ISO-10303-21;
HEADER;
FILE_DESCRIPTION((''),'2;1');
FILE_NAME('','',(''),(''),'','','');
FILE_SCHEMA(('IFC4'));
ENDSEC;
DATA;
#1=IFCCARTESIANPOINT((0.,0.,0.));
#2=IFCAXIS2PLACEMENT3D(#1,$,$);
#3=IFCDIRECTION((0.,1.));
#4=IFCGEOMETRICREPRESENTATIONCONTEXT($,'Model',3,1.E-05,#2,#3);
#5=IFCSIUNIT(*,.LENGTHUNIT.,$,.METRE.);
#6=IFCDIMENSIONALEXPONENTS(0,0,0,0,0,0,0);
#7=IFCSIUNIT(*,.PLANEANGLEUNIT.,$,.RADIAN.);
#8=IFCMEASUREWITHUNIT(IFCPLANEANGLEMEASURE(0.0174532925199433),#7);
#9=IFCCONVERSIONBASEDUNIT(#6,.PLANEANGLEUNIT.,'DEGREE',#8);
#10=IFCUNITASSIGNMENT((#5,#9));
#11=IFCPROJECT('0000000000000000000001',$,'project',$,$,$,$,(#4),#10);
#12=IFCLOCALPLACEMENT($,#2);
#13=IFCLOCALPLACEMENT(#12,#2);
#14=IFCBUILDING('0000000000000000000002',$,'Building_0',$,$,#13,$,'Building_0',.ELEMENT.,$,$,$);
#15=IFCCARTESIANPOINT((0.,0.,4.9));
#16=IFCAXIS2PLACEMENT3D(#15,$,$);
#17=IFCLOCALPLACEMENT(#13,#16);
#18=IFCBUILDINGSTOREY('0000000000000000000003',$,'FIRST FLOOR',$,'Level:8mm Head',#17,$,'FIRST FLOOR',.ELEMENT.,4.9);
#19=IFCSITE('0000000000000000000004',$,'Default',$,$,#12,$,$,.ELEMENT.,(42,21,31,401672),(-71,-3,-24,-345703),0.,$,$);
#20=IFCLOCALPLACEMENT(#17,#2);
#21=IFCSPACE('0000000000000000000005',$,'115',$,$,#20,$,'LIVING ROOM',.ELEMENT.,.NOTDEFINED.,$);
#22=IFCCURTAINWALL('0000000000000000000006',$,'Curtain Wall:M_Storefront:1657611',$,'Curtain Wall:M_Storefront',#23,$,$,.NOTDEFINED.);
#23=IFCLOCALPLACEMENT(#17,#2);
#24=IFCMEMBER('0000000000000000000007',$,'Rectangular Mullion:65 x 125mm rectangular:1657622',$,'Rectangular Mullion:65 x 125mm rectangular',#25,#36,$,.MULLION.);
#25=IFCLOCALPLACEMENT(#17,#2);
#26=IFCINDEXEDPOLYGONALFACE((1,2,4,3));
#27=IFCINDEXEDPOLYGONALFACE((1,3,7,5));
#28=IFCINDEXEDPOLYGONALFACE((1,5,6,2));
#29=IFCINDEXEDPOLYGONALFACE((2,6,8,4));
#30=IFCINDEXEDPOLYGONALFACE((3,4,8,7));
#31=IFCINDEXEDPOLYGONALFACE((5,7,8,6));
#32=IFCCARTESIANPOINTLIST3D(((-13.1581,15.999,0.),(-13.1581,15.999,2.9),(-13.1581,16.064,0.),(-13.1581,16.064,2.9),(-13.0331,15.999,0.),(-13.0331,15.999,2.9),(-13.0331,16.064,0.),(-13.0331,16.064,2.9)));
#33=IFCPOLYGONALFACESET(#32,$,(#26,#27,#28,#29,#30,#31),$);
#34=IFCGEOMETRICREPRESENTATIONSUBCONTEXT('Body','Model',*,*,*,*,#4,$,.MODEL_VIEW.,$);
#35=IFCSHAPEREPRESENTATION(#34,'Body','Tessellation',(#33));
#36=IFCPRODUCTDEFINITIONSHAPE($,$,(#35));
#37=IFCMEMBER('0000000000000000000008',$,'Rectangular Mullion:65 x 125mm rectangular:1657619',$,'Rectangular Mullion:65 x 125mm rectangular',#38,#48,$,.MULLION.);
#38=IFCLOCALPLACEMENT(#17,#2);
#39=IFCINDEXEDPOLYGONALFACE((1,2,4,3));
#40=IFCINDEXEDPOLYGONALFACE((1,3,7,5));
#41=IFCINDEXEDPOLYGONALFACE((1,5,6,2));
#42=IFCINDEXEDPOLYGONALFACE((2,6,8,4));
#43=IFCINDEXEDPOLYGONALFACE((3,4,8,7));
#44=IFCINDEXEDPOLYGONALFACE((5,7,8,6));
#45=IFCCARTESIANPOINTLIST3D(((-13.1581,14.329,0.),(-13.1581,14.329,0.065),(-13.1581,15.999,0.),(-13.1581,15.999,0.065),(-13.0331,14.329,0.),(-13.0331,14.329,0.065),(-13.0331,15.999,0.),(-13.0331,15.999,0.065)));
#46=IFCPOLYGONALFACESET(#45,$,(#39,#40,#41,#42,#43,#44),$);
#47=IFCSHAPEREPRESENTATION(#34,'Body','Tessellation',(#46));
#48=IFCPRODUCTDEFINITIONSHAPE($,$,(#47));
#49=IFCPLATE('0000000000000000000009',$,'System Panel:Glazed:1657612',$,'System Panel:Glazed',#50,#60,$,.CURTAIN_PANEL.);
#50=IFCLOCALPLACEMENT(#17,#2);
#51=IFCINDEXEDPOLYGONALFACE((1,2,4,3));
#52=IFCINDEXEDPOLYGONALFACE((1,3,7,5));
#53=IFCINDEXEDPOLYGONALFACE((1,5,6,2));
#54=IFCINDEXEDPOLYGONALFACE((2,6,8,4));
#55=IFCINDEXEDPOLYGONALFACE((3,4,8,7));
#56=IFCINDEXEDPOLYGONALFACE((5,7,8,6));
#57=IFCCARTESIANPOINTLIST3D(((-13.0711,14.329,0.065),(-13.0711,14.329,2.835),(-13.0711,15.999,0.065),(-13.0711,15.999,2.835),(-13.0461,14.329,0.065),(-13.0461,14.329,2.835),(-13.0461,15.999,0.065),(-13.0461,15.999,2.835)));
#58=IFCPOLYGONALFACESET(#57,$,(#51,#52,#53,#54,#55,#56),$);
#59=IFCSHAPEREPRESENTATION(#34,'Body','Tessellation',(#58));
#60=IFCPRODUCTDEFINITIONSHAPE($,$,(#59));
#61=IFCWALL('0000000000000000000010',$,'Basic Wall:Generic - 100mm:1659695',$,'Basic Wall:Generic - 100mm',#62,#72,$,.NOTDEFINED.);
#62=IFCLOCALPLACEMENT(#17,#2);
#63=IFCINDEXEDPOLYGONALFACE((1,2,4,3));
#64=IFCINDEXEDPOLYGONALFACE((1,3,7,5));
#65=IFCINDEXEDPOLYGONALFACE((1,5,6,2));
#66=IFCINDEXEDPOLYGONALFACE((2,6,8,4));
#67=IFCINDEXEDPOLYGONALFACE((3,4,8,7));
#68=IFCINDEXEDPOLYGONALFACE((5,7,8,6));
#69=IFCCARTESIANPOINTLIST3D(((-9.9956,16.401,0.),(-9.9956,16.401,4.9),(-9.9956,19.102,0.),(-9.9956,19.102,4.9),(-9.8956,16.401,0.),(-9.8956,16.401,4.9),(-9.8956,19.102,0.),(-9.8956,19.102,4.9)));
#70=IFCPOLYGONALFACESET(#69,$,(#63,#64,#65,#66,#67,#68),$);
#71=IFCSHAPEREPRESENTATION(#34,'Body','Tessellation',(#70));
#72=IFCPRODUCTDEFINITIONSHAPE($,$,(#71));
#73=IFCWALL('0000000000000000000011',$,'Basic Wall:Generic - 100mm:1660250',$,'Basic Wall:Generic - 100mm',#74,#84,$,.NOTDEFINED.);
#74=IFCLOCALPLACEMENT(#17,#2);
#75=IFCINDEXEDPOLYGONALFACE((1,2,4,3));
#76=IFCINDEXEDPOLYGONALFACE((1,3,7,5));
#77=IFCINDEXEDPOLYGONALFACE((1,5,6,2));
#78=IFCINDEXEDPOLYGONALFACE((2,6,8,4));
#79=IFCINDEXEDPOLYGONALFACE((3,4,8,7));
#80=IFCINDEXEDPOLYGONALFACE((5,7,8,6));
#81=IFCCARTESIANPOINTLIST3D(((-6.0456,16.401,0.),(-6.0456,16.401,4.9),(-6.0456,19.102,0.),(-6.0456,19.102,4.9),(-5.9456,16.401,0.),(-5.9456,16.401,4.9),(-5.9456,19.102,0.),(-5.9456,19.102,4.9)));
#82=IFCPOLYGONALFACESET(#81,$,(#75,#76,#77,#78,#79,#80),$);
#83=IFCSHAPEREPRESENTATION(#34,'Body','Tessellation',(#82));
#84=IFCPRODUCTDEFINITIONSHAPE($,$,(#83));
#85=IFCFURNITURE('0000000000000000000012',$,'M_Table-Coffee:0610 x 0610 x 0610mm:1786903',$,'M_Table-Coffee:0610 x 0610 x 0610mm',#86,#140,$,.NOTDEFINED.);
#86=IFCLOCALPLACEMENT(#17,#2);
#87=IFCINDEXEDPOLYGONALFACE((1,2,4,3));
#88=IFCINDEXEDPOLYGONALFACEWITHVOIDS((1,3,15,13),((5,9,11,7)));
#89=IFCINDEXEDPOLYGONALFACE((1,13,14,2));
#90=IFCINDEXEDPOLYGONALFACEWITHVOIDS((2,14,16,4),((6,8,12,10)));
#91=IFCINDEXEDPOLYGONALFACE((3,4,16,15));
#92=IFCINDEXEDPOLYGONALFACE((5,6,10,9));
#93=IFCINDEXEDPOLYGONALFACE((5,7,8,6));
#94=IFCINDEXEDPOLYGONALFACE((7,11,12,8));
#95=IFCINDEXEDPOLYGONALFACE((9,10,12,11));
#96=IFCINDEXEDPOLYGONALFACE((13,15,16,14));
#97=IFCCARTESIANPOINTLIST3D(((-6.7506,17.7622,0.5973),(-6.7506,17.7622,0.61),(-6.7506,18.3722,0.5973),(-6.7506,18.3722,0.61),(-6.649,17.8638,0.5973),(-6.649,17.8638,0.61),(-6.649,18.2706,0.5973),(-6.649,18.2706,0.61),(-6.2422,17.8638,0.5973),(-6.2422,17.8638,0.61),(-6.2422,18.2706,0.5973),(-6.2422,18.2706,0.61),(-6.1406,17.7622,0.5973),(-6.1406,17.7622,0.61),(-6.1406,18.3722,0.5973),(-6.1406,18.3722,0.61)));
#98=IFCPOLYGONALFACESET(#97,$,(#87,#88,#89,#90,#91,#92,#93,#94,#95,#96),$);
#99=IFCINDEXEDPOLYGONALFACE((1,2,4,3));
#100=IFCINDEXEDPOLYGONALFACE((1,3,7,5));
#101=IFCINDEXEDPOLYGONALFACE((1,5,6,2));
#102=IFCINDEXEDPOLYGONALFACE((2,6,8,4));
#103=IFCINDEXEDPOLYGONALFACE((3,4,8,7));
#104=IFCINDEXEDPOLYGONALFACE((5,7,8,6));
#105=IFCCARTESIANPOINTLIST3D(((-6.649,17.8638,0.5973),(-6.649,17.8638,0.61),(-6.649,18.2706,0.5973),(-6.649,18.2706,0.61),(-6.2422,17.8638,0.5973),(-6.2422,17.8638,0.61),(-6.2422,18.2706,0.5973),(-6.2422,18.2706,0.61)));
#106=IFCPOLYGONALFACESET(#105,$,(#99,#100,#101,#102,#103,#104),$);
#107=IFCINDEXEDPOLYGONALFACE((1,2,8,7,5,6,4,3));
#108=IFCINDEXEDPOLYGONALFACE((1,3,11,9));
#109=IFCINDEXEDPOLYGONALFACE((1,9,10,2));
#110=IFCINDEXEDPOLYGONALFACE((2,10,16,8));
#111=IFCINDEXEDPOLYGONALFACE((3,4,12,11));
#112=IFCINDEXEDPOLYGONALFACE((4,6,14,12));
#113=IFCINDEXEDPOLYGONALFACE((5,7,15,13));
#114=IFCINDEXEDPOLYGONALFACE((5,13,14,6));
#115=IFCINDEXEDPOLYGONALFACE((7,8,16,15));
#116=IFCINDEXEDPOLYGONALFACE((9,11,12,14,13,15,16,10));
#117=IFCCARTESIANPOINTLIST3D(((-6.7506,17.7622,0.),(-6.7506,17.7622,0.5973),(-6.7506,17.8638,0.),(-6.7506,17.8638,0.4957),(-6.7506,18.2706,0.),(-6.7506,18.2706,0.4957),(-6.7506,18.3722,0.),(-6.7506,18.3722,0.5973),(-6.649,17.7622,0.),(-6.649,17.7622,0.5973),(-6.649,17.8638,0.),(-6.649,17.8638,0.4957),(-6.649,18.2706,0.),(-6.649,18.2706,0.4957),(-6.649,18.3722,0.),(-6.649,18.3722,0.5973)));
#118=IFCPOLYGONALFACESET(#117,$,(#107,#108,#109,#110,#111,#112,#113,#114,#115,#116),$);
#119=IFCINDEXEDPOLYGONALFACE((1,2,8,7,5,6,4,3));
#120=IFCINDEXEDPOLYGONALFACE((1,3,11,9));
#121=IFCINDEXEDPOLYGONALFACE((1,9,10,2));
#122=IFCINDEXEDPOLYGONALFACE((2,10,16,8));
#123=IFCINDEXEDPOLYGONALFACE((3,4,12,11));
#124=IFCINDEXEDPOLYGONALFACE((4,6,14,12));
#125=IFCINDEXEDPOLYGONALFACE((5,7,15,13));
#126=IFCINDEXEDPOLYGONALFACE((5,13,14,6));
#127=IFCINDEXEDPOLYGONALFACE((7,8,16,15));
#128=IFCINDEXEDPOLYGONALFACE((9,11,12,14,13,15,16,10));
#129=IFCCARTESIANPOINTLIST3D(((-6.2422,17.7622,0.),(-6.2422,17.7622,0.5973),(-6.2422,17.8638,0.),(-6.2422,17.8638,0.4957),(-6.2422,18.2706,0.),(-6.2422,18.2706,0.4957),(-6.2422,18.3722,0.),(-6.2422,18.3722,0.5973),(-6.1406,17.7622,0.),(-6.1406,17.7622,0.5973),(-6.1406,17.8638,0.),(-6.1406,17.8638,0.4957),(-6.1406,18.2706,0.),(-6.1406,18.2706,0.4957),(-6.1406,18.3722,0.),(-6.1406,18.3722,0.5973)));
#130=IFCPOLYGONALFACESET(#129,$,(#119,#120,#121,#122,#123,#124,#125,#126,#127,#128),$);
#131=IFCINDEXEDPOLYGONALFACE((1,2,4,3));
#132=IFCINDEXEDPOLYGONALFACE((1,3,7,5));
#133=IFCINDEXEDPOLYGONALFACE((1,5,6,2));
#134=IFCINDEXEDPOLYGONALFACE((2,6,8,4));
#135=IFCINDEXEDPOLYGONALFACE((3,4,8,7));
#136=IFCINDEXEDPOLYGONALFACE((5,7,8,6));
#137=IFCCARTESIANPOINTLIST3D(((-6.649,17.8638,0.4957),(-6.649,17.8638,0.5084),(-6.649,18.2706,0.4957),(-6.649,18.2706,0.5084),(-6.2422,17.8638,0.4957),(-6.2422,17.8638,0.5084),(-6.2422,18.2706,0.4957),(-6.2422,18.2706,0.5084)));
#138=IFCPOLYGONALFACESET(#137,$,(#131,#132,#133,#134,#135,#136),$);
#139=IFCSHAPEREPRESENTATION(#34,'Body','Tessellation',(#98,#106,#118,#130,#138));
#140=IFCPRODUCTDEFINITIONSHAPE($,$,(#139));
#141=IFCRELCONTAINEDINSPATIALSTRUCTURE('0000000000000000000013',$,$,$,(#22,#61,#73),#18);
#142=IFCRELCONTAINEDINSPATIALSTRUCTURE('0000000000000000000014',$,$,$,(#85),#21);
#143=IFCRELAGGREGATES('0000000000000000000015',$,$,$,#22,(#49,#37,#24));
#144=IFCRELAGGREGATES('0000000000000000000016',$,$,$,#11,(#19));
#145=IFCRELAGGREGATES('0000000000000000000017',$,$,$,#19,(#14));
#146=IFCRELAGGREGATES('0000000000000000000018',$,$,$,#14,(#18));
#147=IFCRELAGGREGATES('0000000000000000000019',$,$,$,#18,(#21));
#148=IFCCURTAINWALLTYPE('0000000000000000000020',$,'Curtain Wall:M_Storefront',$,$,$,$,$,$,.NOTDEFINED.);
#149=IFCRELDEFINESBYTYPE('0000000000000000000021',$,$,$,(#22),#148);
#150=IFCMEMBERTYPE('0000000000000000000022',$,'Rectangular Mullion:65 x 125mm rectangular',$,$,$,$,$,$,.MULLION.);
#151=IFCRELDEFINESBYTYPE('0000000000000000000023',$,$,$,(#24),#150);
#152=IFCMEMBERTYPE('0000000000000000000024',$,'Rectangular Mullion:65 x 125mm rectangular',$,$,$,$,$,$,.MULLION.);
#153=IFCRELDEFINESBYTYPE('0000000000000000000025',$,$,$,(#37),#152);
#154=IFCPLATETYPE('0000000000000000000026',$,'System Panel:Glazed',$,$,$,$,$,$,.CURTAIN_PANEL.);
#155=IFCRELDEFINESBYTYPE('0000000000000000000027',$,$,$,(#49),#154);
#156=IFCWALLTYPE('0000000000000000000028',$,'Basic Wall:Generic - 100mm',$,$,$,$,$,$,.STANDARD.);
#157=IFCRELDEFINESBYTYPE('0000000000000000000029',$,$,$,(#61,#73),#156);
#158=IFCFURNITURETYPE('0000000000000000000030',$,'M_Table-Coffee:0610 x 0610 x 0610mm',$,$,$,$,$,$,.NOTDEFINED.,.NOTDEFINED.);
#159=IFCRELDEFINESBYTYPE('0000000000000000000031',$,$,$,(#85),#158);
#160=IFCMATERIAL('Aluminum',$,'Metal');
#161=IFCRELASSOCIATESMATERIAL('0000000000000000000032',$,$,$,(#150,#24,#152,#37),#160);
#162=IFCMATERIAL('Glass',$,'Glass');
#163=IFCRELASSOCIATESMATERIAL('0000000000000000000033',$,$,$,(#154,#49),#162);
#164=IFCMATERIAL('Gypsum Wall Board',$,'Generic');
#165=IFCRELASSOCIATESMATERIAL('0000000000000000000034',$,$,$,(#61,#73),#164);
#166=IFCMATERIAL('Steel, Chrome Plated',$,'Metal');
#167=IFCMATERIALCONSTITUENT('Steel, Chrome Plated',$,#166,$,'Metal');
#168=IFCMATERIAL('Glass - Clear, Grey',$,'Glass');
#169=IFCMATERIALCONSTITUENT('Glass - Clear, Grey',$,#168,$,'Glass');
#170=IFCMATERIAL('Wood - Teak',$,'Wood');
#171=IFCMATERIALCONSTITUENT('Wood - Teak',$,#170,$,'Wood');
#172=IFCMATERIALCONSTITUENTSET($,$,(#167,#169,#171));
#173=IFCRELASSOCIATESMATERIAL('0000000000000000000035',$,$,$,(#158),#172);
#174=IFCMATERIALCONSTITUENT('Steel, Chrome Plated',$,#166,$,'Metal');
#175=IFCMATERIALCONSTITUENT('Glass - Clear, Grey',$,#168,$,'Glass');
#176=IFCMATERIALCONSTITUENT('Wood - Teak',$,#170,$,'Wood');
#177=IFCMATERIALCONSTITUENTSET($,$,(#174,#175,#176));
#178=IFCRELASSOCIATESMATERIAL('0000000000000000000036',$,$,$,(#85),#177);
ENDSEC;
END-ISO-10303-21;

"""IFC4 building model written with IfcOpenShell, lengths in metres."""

from ifc_helpers import new_model, entity, si_unit, converted_unit, direction, frame, origin, place, context, subcontext, project, spatial, indexed_curve, outline, extrude, source, transform, mapped, material, constituent, constituent_set, type_object, type_shapes, element, aggregate, save


model = new_model("IFC4")

# Units and contexts
model_context = context("Model", 3, precision=1e-05, world=origin(), true_north=direction((0.0, 1.0)))
body_context = subcontext(model_context, "Body", "Model", "MODEL_VIEW")
ifc_project = project(units=[si_unit("LENGTHUNIT", "METRE"), converted_unit("PLANEANGLEUNIT", "DEGREE", entity("IfcPlaneAngleMeasure", 0.0174532925199433), si_unit("PLANEANGLEUNIT", "RADIAN"), dimensions=[0, 0, 0, 0, 0, 0, 0])], contexts=[model_context])

# Site, building, storey
site_placement = place(None, origin())
site = spatial("IfcSite", under=ifc_project, at=site_placement, Name="Default", CompositionType="ELEMENT", RefLatitude=(42, 21, 31, 401672), RefLongitude=(-71, -3, -24, -345703), RefElevation=0.0)
building_placement = place(site_placement, origin())
building = spatial("IfcBuilding", under=site, at=building_placement, Name="Building_0", LongName="Building_0", CompositionType="ELEMENT")
storey_placement = place(building_placement, frame((0.0, 0.0, 4.9)))
storey = spatial("IfcBuildingStorey", under=building, at=storey_placement, Name="FIRST FLOOR", ObjectType="Level:8mm Head", LongName="FIRST FLOOR", CompositionType="ELEMENT", Elevation=4.9)

# Curtain wall, members, plate
curtain_wall_type = type_object("IfcCurtainWallType", Name="Curtain Wall:M_Storefront", PredefinedType="NOTDEFINED")
curtain_wall_placement = place(storey_placement, frame((0.0, 0.0, -4.9)))
curtain_wall = element("IfcCurtainWall", 1, at=curtain_wall_placement, inside=storey, type_object=curtain_wall_type, Name="Curtain Wall:M_Storefront:1657611", ObjectType="Curtain Wall:M_Storefront", PredefinedType="NOTDEFINED")
ifc_material_1 = material(Name="Aluminum", Category="Metal")
member_type_1 = type_object("IfcMemberType", Name="Rectangular Mullion:65 x 125mm rectangular", PredefinedType="MULLION", material=ifc_material_1)
shared_shape_1 = source(origin(), body_context, "Body", "SweptSolid", [
    extrude(outline(indexed_curve([(-0.0325, -0.0625), (0.0325, -0.0625), (0.0325, 0.0625), (-0.0325, 0.0625), (-0.0325, -0.0625)], self_intersect=False)), frame((-0.0325, 0.0, -2.9), z_axis=(0.0, 0.0, 1.0), x_axis=(-1.0, 0.0, 0.0)), (0.0, 0.0, 1.0), 2.9),
])
type_shapes(member_type_1, [shared_shape_1])
member_1_placement = place(curtain_wall_placement, frame((-13.0956, 16.064, 7.8), z_axis=(0.0, 0.0, 1.0), x_axis=(0.0, 1.0, 0.0)))
member_1 = element("IfcMember", 2, at=member_1_placement, type_object=member_type_1, material=ifc_material_1, Name="Rectangular Mullion:65 x 125mm rectangular:1657622", ObjectType="Rectangular Mullion:65 x 125mm rectangular", PredefinedType="MULLION", context=body_context, shape_type="MappedRepresentation", body=[
    mapped(shared_shape_1, transform((0.0, 0.0, 0.0), scale=1.0)),
])
member_type_2 = type_object("IfcMemberType", Name="Rectangular Mullion:65 x 125mm rectangular", PredefinedType="MULLION", material=ifc_material_1)
shared_shape_2 = source(origin(), body_context, "Body", "SweptSolid", [
    extrude(outline(indexed_curve([(-0.0325, -0.0625), (0.0325, -0.0625), (0.0325, 0.0625), (-0.0325, 0.0625), (-0.0325, -0.0625)], self_intersect=False)), frame((-0.0325, 0.0, -1.67), z_axis=(0.0, 0.0, 1.0), x_axis=(-1.0, 0.0, 0.0)), (0.0, 0.0, 1.0), 1.67),
])
type_shapes(member_type_2, [shared_shape_2])
member_2_placement = place(curtain_wall_placement, frame((-13.0956, 15.999, 4.9), z_axis=(0.0, 1.0, 0.0), x_axis=(0.0, 0.0, -1.0)))
member_2 = element("IfcMember", 3, at=member_2_placement, type_object=member_type_2, material=ifc_material_1, Name="Rectangular Mullion:65 x 125mm rectangular:1657619", ObjectType="Rectangular Mullion:65 x 125mm rectangular", PredefinedType="MULLION", context=body_context, shape_type="MappedRepresentation", body=[
    mapped(shared_shape_2, transform((0.0, 0.0, 0.0), scale=1.0)),
])
ifc_material_2 = material(Name="Glass", Category="Glass")
plate_type = type_object("IfcPlateType", Name="System Panel:Glazed", PredefinedType="CURTAIN_PANEL", material=ifc_material_2)
shared_shape_3 = source(origin(), body_context, "Body", "SweptSolid", [
    extrude(outline(indexed_curve([(-0.0125, -0.835), (0.0125, -0.835), (0.0125, 0.835), (-0.0125, 0.835), (-0.0125, -0.835)], self_intersect=False)), frame((0.0, 0.037, 0.0), z_axis=(0.0, 0.0, 1.0), x_axis=(0.0, 1.0, 0.0)), (0.0, 0.0, 1.0), 2.77),
])
type_shapes(plate_type, [shared_shape_3])
plate_placement = place(curtain_wall_placement, frame((-13.0956, 15.164, 4.965), z_axis=(0.0, 0.0, 1.0), x_axis=(0.0, -1.0, 0.0)))
plate = element("IfcPlate", 4, at=plate_placement, type_object=plate_type, material=ifc_material_2, Name="System Panel:Glazed:1657612", ObjectType="System Panel:Glazed", PredefinedType="CURTAIN_PANEL", context=body_context, shape_type="MappedRepresentation", body=[
    mapped(shared_shape_3, transform((0.0, 0.0, 0.0), scale=1.0)),
])
aggregate(curtain_wall, [plate, member_2, member_1])

# Walls
ifc_material_3 = material(Name="Gypsum Wall Board", Category="Generic")
wall_type_1 = type_object("IfcWallType", Name="Basic Wall:Generic - 100mm", PredefinedType="STANDARD")
wall_1_placement = place(storey_placement, frame((-9.9456, 19.102, 0.0), z_axis=(0.0, 0.0, 1.0), x_axis=(0.0, -1.0, 0.0)))
element("IfcWall", 5, at=wall_1_placement, inside=storey, type_object=wall_type_1, material=ifc_material_3, Name="Basic Wall:Generic - 100mm:1659695", ObjectType="Basic Wall:Generic - 100mm", PredefinedType="NOTDEFINED", context=body_context, shape_type="SweptSolid", body=[
    extrude(outline(indexed_curve([(2.701, 0.05), (0.0, 0.05), (0.0, -0.05), (2.701, -0.05), (2.701, 0.05)], self_intersect=False)), origin(), (0.0, 0.0, 1.0), 4.9),
])
wall_2_placement = place(storey_placement, frame((-5.9956, 19.102, 0.0), z_axis=(0.0, 0.0, 1.0), x_axis=(0.0, -1.0, 0.0)))
element("IfcWall", 6, at=wall_2_placement, inside=storey, type_object=wall_type_1, material=ifc_material_3, Name="Basic Wall:Generic - 100mm:1660250", ObjectType="Basic Wall:Generic - 100mm", PredefinedType="NOTDEFINED", context=body_context, shape_type="SweptSolid", body=[
    extrude(outline(indexed_curve([(2.701, 0.05), (0.0, 0.05), (0.0, -0.05), (2.701, -0.05), (2.701, 0.05)], self_intersect=False)), origin(), (0.0, 0.0, 1.0), 4.9),
])

# Shared definitions
space_1_placement = place(storey_placement, origin())
space_1 = spatial("IfcSpace", under=storey, at=space_1_placement, Name="115", LongName="LIVING ROOM", CompositionType="ELEMENT", PredefinedType="NOTDEFINED")

# Furniture
ifc_material_4 = material(Name="Steel, Chrome Plated", Category="Metal")
ifc_constituent_1 = constituent(ifc_material_4, Name="Steel, Chrome Plated", Category="Metal")
ifc_material_5 = material(Name="Glass - Clear, Grey", Category="Glass")
ifc_constituent_2 = constituent(ifc_material_5, Name="Glass - Clear, Grey", Category="Glass")
ifc_material_6 = material(Name="Wood - Teak", Category="Wood")
ifc_constituent_3 = constituent(ifc_material_6, Name="Wood - Teak", Category="Wood")
ifc_constituent_set_1 = constituent_set(constituents=[ifc_constituent_1, ifc_constituent_2, ifc_constituent_3])
ifc_constituent_4 = constituent(ifc_material_4, Name="Steel, Chrome Plated", Category="Metal")
ifc_constituent_5 = constituent(ifc_material_5, Name="Glass - Clear, Grey", Category="Glass")
ifc_constituent_6 = constituent(ifc_material_6, Name="Wood - Teak", Category="Wood")
ifc_constituent_set_2 = constituent_set(constituents=[ifc_constituent_4, ifc_constituent_5, ifc_constituent_6])
furniture_type = type_object("IfcFurnitureType", Name="M_Table-Coffee:0610 x 0610 x 0610mm", AssemblyPlace="NOTDEFINED", PredefinedType="NOTDEFINED", material=ifc_constituent_set_2)
shared_shape_4 = source(origin(), body_context, "Body", "SweptSolid", [
    extrude(outline(indexed_curve([(-0.305, -0.305), (0.305, -0.305), (0.305, 0.305), (-0.305, 0.305), (-0.305, -0.305)], self_intersect=False), holes=[indexed_curve([(-0.2034, -0.2034), (-0.2034, 0.2034), (0.2034, 0.2034), (0.2034, -0.2034), (-0.2034, -0.2034)], self_intersect=False)]), frame((0.0183, 0.0952, 0.5973), z_axis=(0.0, 0.0, 1.0), x_axis=(-1.0, 0.0, 0.0)), (0.0, 0.0, 1.0), 0.0127),
    extrude(outline(indexed_curve([(-0.2034, -0.2034), (0.2034, -0.2034), (0.2034, 0.2034), (-0.2034, 0.2034), (-0.2034, -0.2034)], self_intersect=False)), frame((0.0183, 0.0952, 0.5973), z_axis=(0.0, 0.0, 1.0), x_axis=(-1.0, 0.0, 0.0)), (0.0, 0.0, 1.0), 0.0127),
    extrude(outline(indexed_curve([(-0.305, -0.3241), (0.305, -0.3241), (0.305, 0.2733), (0.2034, 0.2733), (0.2034, -0.2224), (-0.2034, -0.2224), (-0.2034, 0.2733), (-0.305, 0.2733), (-0.305, -0.3241)], self_intersect=False)), frame((-0.2867, 0.0952, 0.2733), z_axis=(1.0, 0.0, 0.0), x_axis=(0.0, -1.0, 0.0)), (0.0, 0.0, 1.0), 0.1016),
    extrude(outline(indexed_curve([(-0.2732, -0.305), (0.324, -0.305), (0.324, 0.305), (-0.2732, 0.305), (-0.2732, 0.2034), (0.2225, 0.2034), (0.2225, -0.2034), (-0.2732, -0.2034), (-0.2732, -0.305)], self_intersect=False)), frame((0.2217, 0.0952, 0.2732), z_axis=(1.0, 0.0, 0.0), x_axis=(0.0, 0.0, 1.0)), (0.0, 0.0, 1.0), 0.1016),
    extrude(outline(indexed_curve([(-0.2034, -0.2034), (0.2034, -0.2034), (0.2034, 0.2034), (-0.2034, 0.2034), (-0.2034, -0.2034)], self_intersect=False)), frame((0.0183, 0.0952, 0.4957), z_axis=(0.0, 0.0, 1.0), x_axis=(-1.0, 0.0, 0.0)), (0.0, 0.0, 1.0), 0.0127),
])
type_shapes(furniture_type, [shared_shape_4])
furniture_placement = place(space_1_placement, frame((-6.4639, 17.972, 0.0)))
element("IfcFurniture", 7, at=furniture_placement, inside=space_1, type_object=furniture_type, material=ifc_constituent_set_1, Name="M_Table-Coffee:0610 x 0610 x 0610mm:1786903", ObjectType="M_Table-Coffee:0610 x 0610 x 0610mm", PredefinedType="NOTDEFINED", context=body_context, shape_type="MappedRepresentation", body=[
    mapped(shared_shape_4, transform((0.0, 0.0, 0.0), scale=1.0)),
])

save(model, "model.ifc")
